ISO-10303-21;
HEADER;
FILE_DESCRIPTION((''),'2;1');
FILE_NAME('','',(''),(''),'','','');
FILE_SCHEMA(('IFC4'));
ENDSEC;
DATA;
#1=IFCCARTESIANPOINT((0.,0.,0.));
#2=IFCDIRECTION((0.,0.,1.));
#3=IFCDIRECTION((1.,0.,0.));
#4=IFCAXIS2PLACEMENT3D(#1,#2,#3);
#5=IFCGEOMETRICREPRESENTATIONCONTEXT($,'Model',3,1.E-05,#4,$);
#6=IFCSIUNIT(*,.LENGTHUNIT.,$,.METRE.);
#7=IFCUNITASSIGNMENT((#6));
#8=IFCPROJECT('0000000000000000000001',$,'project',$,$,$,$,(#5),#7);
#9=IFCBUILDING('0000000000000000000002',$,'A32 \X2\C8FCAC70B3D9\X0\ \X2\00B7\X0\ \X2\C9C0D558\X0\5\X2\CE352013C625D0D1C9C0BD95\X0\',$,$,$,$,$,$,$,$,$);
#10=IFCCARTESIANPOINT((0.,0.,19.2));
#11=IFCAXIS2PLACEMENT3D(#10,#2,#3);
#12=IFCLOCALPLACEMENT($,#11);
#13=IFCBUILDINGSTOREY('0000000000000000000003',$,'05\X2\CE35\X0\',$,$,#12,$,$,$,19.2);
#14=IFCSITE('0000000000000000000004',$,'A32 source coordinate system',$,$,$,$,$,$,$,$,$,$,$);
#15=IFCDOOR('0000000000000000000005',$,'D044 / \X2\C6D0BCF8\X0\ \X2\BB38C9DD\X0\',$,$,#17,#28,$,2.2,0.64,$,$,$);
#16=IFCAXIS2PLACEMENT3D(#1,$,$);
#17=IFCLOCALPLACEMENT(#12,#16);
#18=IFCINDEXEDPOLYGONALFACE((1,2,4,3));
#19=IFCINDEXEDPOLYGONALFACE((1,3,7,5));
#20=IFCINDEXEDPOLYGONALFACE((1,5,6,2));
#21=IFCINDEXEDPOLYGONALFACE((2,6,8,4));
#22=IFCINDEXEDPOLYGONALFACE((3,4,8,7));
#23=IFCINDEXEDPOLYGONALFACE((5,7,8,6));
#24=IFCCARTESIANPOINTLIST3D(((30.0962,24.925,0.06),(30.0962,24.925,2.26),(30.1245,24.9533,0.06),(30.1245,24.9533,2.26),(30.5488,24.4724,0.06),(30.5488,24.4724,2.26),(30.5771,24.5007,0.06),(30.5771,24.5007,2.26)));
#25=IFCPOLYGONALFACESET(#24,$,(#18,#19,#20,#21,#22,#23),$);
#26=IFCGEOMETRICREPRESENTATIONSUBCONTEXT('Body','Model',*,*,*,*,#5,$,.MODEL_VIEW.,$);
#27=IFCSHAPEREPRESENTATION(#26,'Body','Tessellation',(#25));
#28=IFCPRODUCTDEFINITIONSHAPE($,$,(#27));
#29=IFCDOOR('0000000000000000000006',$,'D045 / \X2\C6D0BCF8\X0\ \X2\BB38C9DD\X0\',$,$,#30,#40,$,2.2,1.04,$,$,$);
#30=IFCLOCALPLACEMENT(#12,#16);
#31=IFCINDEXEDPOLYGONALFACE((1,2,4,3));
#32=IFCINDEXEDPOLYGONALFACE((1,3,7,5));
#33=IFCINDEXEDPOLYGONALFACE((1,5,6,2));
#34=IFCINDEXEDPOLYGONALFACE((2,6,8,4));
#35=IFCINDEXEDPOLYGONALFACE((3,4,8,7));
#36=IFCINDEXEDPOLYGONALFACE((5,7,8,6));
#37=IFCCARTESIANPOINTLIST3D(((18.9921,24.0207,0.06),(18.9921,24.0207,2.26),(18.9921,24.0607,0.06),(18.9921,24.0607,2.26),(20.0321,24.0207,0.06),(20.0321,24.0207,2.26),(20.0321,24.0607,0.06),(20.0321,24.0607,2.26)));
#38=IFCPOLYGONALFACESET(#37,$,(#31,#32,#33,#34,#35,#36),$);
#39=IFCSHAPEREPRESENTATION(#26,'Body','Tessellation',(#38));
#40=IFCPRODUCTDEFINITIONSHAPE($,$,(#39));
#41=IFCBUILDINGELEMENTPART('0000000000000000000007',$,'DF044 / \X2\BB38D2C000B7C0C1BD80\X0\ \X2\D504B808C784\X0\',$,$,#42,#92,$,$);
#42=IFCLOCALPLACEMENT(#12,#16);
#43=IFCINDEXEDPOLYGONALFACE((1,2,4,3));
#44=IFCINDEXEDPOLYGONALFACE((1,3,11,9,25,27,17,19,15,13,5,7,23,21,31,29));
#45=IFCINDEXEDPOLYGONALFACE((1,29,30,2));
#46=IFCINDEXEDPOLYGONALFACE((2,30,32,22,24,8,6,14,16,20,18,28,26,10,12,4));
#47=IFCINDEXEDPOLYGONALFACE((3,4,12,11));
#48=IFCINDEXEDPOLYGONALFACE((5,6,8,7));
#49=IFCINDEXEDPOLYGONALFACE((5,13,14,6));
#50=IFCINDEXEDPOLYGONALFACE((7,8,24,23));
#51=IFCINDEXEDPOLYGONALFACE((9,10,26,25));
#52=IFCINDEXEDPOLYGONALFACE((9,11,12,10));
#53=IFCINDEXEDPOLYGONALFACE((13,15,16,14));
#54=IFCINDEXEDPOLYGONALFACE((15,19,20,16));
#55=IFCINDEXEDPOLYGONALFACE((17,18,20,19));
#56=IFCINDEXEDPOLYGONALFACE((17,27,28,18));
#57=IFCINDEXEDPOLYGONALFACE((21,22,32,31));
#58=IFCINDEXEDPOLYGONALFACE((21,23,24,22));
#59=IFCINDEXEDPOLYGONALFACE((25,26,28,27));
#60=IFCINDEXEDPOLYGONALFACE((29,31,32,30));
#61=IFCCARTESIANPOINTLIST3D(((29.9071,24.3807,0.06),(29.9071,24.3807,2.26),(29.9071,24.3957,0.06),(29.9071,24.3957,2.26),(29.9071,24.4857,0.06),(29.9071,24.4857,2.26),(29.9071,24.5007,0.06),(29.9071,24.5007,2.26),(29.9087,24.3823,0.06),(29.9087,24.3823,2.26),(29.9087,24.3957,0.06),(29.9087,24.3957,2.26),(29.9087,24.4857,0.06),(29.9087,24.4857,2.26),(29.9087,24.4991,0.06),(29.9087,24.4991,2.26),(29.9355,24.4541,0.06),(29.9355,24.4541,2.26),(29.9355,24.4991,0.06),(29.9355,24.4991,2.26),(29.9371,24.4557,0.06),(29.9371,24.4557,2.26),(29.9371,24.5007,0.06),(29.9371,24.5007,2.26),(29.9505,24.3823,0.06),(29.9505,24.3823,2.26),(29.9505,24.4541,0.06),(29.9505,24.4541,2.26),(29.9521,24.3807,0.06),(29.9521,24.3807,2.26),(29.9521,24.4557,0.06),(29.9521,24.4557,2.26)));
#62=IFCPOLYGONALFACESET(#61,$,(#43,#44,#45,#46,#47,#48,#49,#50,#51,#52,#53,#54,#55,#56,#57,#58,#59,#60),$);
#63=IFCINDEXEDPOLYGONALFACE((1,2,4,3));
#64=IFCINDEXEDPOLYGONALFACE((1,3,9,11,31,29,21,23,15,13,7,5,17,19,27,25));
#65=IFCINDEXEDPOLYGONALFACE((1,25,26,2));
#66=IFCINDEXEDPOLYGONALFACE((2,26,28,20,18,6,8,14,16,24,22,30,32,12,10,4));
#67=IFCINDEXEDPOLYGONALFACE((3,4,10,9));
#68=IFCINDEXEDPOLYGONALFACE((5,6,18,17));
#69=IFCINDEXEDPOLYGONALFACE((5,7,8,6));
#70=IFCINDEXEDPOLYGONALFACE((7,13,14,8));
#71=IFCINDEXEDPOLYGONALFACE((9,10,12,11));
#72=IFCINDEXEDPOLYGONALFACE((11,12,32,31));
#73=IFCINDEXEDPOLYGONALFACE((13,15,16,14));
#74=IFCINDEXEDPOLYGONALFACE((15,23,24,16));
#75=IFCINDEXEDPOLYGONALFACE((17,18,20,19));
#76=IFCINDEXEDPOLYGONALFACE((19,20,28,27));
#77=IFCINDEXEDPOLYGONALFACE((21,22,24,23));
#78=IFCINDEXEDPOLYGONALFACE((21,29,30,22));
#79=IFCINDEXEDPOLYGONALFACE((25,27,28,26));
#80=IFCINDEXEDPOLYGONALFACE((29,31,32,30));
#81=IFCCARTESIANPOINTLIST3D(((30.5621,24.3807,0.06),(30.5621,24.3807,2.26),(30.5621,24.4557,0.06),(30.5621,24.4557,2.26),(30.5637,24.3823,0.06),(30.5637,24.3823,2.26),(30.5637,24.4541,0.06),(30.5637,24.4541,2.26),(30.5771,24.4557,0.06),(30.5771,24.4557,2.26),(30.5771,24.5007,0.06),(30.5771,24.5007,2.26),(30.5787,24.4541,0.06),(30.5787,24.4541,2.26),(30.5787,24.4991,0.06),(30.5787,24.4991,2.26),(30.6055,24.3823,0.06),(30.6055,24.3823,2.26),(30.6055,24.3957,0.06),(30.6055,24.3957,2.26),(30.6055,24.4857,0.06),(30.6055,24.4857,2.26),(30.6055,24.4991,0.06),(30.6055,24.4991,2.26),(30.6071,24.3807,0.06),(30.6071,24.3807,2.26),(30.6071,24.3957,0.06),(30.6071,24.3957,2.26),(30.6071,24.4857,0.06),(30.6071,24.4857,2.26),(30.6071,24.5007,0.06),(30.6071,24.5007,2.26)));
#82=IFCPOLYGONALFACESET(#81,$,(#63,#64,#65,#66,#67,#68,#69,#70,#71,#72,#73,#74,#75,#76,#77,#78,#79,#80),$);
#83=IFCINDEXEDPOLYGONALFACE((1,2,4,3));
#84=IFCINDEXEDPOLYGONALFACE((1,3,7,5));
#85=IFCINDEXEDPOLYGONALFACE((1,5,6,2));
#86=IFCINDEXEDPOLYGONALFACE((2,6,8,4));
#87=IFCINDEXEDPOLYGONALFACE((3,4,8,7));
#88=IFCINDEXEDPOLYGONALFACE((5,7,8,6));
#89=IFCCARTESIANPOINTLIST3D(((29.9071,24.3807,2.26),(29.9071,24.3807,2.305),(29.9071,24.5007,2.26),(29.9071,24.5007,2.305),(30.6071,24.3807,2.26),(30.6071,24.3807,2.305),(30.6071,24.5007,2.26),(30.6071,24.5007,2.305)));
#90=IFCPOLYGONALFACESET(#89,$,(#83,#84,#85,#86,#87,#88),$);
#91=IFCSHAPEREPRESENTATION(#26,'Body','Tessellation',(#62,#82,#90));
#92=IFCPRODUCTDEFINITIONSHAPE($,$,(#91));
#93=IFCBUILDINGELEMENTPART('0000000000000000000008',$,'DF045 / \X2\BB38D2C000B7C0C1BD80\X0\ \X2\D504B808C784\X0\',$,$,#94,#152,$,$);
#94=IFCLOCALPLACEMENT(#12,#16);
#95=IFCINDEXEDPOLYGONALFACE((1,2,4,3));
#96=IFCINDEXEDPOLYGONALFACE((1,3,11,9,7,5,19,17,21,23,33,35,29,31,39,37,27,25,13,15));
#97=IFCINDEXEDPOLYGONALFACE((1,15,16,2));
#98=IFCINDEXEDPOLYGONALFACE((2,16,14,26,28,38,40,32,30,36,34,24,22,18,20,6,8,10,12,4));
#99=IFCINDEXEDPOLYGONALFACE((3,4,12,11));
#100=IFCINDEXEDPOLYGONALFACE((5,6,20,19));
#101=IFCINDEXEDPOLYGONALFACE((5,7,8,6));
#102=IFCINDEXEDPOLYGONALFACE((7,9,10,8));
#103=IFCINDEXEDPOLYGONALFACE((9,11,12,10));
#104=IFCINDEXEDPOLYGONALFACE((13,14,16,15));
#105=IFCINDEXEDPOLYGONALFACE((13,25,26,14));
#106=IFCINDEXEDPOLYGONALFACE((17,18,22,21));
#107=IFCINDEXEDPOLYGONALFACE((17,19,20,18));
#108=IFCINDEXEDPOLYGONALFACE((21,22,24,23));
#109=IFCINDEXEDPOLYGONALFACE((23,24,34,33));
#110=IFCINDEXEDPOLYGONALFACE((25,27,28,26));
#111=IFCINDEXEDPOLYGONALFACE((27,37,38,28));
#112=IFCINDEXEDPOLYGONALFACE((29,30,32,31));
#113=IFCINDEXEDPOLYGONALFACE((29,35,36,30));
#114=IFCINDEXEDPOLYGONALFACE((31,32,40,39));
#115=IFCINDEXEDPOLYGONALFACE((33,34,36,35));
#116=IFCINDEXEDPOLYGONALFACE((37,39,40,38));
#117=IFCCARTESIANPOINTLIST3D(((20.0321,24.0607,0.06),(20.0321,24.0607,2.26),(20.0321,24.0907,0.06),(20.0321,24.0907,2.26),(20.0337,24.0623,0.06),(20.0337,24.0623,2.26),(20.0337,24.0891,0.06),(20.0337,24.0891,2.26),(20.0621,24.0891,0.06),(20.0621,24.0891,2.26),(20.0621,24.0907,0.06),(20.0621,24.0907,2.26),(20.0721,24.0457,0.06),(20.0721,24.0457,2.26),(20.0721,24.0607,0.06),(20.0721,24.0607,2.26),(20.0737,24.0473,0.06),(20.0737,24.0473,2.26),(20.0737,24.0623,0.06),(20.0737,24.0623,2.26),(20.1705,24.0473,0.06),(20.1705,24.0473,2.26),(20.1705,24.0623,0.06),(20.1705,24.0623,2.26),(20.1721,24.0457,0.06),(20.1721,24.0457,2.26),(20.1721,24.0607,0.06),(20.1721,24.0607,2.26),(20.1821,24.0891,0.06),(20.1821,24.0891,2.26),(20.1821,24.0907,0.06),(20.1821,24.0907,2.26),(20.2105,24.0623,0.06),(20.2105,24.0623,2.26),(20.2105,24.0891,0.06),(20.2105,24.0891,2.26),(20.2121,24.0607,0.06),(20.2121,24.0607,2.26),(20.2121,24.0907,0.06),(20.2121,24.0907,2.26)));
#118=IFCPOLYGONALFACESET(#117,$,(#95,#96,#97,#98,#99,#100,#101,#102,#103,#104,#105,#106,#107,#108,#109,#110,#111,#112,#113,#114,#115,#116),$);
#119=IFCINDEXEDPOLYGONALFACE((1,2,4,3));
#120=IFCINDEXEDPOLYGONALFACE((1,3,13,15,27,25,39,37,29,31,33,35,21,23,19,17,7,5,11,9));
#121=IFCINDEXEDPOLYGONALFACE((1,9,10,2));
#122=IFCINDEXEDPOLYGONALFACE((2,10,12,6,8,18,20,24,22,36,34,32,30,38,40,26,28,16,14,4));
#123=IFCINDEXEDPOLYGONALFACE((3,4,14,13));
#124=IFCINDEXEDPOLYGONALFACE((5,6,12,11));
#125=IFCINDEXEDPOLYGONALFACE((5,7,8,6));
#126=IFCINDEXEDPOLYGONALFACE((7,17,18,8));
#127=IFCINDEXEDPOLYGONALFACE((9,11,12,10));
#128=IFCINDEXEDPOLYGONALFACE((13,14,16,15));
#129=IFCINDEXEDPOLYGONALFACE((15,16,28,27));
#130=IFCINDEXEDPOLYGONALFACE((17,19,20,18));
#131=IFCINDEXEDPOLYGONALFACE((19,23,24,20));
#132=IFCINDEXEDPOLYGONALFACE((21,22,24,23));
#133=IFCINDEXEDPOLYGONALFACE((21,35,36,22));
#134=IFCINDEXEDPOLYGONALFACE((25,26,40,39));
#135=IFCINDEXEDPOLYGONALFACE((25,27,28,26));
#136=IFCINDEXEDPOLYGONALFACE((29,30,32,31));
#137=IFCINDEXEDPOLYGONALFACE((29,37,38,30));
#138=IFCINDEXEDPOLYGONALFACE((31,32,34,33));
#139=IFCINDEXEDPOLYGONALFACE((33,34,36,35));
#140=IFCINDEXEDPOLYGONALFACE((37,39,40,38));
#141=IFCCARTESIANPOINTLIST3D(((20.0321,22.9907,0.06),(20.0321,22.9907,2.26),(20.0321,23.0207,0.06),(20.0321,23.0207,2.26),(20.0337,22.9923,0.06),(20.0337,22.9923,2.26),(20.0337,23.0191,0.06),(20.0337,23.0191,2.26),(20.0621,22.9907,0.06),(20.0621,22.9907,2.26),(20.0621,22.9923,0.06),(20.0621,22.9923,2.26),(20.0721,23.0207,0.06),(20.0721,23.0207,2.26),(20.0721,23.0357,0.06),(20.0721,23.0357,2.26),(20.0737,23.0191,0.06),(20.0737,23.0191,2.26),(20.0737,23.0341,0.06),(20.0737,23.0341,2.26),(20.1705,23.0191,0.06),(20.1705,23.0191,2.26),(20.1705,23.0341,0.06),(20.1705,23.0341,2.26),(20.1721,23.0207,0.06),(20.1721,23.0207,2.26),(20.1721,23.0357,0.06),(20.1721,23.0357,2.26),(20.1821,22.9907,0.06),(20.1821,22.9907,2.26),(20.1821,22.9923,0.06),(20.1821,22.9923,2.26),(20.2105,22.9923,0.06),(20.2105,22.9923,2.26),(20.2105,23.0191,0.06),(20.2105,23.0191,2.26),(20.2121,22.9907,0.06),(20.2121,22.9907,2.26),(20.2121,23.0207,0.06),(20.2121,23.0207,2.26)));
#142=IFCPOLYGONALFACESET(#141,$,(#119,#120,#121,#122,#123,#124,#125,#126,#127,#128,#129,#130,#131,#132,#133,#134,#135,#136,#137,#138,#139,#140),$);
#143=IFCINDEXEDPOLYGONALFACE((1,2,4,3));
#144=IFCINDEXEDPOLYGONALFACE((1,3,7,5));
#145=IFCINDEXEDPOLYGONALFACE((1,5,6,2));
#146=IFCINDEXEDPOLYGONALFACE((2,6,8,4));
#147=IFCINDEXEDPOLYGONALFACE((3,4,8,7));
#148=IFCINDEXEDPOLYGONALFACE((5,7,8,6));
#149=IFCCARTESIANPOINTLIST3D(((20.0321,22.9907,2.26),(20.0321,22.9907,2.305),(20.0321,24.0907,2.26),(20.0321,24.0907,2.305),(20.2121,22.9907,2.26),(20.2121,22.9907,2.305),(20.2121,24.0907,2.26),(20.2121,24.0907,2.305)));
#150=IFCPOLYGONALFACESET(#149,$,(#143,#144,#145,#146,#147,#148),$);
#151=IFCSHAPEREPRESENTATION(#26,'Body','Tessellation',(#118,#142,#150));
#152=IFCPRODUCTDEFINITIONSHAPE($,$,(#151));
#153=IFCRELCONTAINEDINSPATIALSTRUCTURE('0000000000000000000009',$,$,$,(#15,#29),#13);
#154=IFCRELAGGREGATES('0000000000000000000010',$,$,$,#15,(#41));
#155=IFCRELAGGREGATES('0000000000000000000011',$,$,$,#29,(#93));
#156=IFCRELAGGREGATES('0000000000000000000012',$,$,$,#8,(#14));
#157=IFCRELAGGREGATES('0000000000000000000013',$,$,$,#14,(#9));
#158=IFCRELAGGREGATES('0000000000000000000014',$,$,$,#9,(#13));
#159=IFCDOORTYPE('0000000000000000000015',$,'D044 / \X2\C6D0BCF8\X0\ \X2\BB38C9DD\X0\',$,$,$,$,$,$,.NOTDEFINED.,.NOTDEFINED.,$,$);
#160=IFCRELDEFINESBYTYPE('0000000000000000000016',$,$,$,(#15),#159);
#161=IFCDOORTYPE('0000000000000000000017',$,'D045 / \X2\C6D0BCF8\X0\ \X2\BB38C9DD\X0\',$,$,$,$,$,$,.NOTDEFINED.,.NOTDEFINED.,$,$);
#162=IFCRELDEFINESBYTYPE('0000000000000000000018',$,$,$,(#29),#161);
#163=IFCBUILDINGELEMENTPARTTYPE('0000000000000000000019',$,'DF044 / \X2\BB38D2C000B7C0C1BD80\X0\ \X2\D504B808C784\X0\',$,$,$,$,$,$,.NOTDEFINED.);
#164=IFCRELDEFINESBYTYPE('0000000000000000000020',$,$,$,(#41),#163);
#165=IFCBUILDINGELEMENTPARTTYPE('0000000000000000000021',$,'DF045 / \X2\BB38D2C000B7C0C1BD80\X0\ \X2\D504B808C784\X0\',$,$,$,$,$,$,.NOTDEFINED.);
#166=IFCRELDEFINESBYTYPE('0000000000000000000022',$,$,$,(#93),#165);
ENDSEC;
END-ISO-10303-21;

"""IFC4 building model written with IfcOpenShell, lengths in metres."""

from ifc_helpers import new_model, si_unit, frame, origin, origin_with_axes, place, context, subcontext, project, spatial, polyline, outline, extrude, source, transform, mapped, type_object, type_shapes, element, aggregate, save


model = new_model("IFC4")

# Units and contexts
model_context = context("Model", 3, precision=1e-05, world=origin_with_axes())
body_context = subcontext(model_context, "Body", "Model", "MODEL_VIEW")
ifc_project = project(units=[si_unit("LENGTHUNIT", "METRE")], contexts=[model_context])

# Site, building, storey
storey_placement = place(None, frame((0.0, 0.0, 19.2), z_axis=(0.0, 0.0, 1.0), x_axis=(1.0, 0.0, 0.0)))
site = spatial("IfcSite", under=ifc_project, Name="A32 source coordinate system")
building = spatial("IfcBuilding", under=site, Name="A32 주거동 · 지하5층–옥탑지붕")
storey = spatial("IfcBuildingStorey", under=building, at=storey_placement, Name="05층", Elevation=19.2)

# Doors
door_type_1 = type_object("IfcDoorType", Name="D044 / 원본 문짝", OperationType="NOTDEFINED", PredefinedType="NOTDEFINED")
shared_shape_1 = source(origin(), body_context, "Body", "SweptSolid", [
    extrude(outline(polyline([(30.5771, 24.5007), (30.5488, 24.4724), (30.0962, 24.925), (30.1245, 24.9533), (30.5771, 24.5007)])), frame((0.0, 0.0, 0.06)), (0.0, 0.0, 1.0), 2.2),
])
type_shapes(door_type_1, [shared_shape_1])
door_1_placement = place(storey_placement, origin_with_axes())
door_1 = element("IfcDoor", 1, at=door_1_placement, inside=storey, type_object=door_type_1, Name="D044 / 원본 문짝", OverallHeight=2.2, OverallWidth=0.64, context=body_context, shape_type="MappedRepresentation", body=[
    mapped(shared_shape_1, transform((0.0, 0.0, 0.0), scale=1.0)),
])
door_type_2 = type_object("IfcDoorType", Name="D045 / 원본 문짝", OperationType="NOTDEFINED", PredefinedType="NOTDEFINED")
shared_shape_2 = source(origin(), body_context, "Body", "SweptSolid", [
    extrude(outline(polyline([(20.0321, 24.0607), (20.0321, 24.0207), (18.9921, 24.0207), (18.9921, 24.0607), (20.0321, 24.0607)])), frame((0.0, 0.0, 0.06)), (0.0, 0.0, 1.0), 2.2),
])
type_shapes(door_type_2, [shared_shape_2])
door_2_placement = place(storey_placement, origin_with_axes())
door_2 = element("IfcDoor", 2, at=door_2_placement, inside=storey, type_object=door_type_2, Name="D045 / 원본 문짝", OverallHeight=2.2, OverallWidth=1.04, context=body_context, shape_type="MappedRepresentation", body=[
    mapped(shared_shape_2, transform((0.0, 0.0, 0.0), scale=1.0)),
])

# Building element parts
building_element_part_type_1 = type_object("IfcBuildingElementPartType", Name="DF044 / 문틀·상부 프레임", PredefinedType="NOTDEFINED")
shared_shape_3 = source(origin(), body_context, "Body", "SweptSolid", [
    extrude(outline(polyline([(29.9071, 24.4857), (29.9071, 24.5007), (29.9371, 24.5007), (29.9371, 24.4557), (29.9521, 24.4557), (29.9521, 24.3807), (29.9071, 24.3807), (29.9071, 24.3957), (29.9087, 24.3957), (29.9087, 24.3823), (29.9505, 24.3823), (29.9505, 24.4541), (29.9355, 24.4541), (29.9355, 24.4991), (29.9087, 24.4991), (29.9087, 24.4857), (29.9071, 24.4857)])), frame((0.0, 0.0, 0.06)), (0.0, 0.0, 1.0), 2.2),
    extrude(outline(polyline([(30.6055, 24.4991), (30.5787, 24.4991), (30.5787, 24.4541), (30.5637, 24.4541), (30.5637, 24.3823), (30.6055, 24.3823), (30.6055, 24.3957), (30.6071, 24.3957), (30.6071, 24.3807), (30.5621, 24.3807), (30.5621, 24.4557), (30.5771, 24.4557), (30.5771, 24.5007), (30.6071, 24.5007), (30.6071, 24.4857), (30.6055, 24.4857), (30.6055, 24.4991)])), frame((0.0, 0.0, 0.06)), (0.0, 0.0, 1.0), 2.2),
    extrude(outline(polyline([(29.9071, 24.3807), (29.9071, 24.5007), (30.6071, 24.5007), (30.6071, 24.3807), (29.9071, 24.3807)])), frame((0.0, 0.0, 2.26)), (0.0, 0.0, 1.0), 0.045),
])
type_shapes(building_element_part_type_1, [shared_shape_3])
building_element_part_1_placement = place(door_1_placement, origin_with_axes())
building_element_part_1 = element("IfcBuildingElementPart", 3, at=building_element_part_1_placement, type_object=building_element_part_type_1, Name="DF044 / 문틀·상부 프레임", context=body_context, shape_type="MappedRepresentation", body=[
    mapped(shared_shape_3, transform((0.0, 0.0, 0.0), scale=1.0)),
])
aggregate(door_1, [building_element_part_1])
building_element_part_type_2 = type_object("IfcBuildingElementPartType", Name="DF045 / 문틀·상부 프레임", PredefinedType="NOTDEFINED")
shared_shape_4 = source(origin(), body_context, "Body", "SweptSolid", [
    extrude(outline(polyline([(20.0337, 24.0891), (20.0337, 24.0623), (20.0737, 24.0623), (20.0737, 24.0473), (20.1705, 24.0473), (20.1705, 24.0623), (20.2105, 24.0623), (20.2105, 24.0891), (20.1821, 24.0891), (20.1821, 24.0907), (20.2121, 24.0907), (20.2121, 24.0607), (20.1721, 24.0607), (20.1721, 24.0457), (20.0721, 24.0457), (20.0721, 24.0607), (20.0321, 24.0607), (20.0321, 24.0907), (20.0621, 24.0907), (20.0621, 24.0891), (20.0337, 24.0891)])), frame((0.0, 0.0, 0.06)), (0.0, 0.0, 1.0), 2.2),
    extrude(outline(polyline([(20.0621, 22.9907), (20.0321, 22.9907), (20.0321, 23.0207), (20.0721, 23.0207), (20.0721, 23.0357), (20.1721, 23.0357), (20.1721, 23.0207), (20.2121, 23.0207), (20.2121, 22.9907), (20.1821, 22.9907), (20.1821, 22.9923), (20.2105, 22.9923), (20.2105, 23.0191), (20.1705, 23.0191), (20.1705, 23.0341), (20.0737, 23.0341), (20.0737, 23.0191), (20.0337, 23.0191), (20.0337, 22.9923), (20.0621, 22.9923), (20.0621, 22.9907)])), frame((0.0, 0.0, 0.06)), (0.0, 0.0, 1.0), 2.2),
    extrude(outline(polyline([(20.0321, 22.9907), (20.0321, 24.0907), (20.2121, 24.0907), (20.2121, 22.9907), (20.0321, 22.9907)])), frame((0.0, 0.0, 2.26)), (0.0, 0.0, 1.0), 0.045),
])
type_shapes(building_element_part_type_2, [shared_shape_4])
building_element_part_2_placement = place(door_2_placement, origin_with_axes())
building_element_part_2 = element("IfcBuildingElementPart", 4, at=building_element_part_2_placement, type_object=building_element_part_type_2, Name="DF045 / 문틀·상부 프레임", context=body_context, shape_type="MappedRepresentation", body=[
    mapped(shared_shape_4, transform((0.0, 0.0, 0.0), scale=1.0)),
])
aggregate(door_2, [building_element_part_2])

save(model, "model.ifc")
